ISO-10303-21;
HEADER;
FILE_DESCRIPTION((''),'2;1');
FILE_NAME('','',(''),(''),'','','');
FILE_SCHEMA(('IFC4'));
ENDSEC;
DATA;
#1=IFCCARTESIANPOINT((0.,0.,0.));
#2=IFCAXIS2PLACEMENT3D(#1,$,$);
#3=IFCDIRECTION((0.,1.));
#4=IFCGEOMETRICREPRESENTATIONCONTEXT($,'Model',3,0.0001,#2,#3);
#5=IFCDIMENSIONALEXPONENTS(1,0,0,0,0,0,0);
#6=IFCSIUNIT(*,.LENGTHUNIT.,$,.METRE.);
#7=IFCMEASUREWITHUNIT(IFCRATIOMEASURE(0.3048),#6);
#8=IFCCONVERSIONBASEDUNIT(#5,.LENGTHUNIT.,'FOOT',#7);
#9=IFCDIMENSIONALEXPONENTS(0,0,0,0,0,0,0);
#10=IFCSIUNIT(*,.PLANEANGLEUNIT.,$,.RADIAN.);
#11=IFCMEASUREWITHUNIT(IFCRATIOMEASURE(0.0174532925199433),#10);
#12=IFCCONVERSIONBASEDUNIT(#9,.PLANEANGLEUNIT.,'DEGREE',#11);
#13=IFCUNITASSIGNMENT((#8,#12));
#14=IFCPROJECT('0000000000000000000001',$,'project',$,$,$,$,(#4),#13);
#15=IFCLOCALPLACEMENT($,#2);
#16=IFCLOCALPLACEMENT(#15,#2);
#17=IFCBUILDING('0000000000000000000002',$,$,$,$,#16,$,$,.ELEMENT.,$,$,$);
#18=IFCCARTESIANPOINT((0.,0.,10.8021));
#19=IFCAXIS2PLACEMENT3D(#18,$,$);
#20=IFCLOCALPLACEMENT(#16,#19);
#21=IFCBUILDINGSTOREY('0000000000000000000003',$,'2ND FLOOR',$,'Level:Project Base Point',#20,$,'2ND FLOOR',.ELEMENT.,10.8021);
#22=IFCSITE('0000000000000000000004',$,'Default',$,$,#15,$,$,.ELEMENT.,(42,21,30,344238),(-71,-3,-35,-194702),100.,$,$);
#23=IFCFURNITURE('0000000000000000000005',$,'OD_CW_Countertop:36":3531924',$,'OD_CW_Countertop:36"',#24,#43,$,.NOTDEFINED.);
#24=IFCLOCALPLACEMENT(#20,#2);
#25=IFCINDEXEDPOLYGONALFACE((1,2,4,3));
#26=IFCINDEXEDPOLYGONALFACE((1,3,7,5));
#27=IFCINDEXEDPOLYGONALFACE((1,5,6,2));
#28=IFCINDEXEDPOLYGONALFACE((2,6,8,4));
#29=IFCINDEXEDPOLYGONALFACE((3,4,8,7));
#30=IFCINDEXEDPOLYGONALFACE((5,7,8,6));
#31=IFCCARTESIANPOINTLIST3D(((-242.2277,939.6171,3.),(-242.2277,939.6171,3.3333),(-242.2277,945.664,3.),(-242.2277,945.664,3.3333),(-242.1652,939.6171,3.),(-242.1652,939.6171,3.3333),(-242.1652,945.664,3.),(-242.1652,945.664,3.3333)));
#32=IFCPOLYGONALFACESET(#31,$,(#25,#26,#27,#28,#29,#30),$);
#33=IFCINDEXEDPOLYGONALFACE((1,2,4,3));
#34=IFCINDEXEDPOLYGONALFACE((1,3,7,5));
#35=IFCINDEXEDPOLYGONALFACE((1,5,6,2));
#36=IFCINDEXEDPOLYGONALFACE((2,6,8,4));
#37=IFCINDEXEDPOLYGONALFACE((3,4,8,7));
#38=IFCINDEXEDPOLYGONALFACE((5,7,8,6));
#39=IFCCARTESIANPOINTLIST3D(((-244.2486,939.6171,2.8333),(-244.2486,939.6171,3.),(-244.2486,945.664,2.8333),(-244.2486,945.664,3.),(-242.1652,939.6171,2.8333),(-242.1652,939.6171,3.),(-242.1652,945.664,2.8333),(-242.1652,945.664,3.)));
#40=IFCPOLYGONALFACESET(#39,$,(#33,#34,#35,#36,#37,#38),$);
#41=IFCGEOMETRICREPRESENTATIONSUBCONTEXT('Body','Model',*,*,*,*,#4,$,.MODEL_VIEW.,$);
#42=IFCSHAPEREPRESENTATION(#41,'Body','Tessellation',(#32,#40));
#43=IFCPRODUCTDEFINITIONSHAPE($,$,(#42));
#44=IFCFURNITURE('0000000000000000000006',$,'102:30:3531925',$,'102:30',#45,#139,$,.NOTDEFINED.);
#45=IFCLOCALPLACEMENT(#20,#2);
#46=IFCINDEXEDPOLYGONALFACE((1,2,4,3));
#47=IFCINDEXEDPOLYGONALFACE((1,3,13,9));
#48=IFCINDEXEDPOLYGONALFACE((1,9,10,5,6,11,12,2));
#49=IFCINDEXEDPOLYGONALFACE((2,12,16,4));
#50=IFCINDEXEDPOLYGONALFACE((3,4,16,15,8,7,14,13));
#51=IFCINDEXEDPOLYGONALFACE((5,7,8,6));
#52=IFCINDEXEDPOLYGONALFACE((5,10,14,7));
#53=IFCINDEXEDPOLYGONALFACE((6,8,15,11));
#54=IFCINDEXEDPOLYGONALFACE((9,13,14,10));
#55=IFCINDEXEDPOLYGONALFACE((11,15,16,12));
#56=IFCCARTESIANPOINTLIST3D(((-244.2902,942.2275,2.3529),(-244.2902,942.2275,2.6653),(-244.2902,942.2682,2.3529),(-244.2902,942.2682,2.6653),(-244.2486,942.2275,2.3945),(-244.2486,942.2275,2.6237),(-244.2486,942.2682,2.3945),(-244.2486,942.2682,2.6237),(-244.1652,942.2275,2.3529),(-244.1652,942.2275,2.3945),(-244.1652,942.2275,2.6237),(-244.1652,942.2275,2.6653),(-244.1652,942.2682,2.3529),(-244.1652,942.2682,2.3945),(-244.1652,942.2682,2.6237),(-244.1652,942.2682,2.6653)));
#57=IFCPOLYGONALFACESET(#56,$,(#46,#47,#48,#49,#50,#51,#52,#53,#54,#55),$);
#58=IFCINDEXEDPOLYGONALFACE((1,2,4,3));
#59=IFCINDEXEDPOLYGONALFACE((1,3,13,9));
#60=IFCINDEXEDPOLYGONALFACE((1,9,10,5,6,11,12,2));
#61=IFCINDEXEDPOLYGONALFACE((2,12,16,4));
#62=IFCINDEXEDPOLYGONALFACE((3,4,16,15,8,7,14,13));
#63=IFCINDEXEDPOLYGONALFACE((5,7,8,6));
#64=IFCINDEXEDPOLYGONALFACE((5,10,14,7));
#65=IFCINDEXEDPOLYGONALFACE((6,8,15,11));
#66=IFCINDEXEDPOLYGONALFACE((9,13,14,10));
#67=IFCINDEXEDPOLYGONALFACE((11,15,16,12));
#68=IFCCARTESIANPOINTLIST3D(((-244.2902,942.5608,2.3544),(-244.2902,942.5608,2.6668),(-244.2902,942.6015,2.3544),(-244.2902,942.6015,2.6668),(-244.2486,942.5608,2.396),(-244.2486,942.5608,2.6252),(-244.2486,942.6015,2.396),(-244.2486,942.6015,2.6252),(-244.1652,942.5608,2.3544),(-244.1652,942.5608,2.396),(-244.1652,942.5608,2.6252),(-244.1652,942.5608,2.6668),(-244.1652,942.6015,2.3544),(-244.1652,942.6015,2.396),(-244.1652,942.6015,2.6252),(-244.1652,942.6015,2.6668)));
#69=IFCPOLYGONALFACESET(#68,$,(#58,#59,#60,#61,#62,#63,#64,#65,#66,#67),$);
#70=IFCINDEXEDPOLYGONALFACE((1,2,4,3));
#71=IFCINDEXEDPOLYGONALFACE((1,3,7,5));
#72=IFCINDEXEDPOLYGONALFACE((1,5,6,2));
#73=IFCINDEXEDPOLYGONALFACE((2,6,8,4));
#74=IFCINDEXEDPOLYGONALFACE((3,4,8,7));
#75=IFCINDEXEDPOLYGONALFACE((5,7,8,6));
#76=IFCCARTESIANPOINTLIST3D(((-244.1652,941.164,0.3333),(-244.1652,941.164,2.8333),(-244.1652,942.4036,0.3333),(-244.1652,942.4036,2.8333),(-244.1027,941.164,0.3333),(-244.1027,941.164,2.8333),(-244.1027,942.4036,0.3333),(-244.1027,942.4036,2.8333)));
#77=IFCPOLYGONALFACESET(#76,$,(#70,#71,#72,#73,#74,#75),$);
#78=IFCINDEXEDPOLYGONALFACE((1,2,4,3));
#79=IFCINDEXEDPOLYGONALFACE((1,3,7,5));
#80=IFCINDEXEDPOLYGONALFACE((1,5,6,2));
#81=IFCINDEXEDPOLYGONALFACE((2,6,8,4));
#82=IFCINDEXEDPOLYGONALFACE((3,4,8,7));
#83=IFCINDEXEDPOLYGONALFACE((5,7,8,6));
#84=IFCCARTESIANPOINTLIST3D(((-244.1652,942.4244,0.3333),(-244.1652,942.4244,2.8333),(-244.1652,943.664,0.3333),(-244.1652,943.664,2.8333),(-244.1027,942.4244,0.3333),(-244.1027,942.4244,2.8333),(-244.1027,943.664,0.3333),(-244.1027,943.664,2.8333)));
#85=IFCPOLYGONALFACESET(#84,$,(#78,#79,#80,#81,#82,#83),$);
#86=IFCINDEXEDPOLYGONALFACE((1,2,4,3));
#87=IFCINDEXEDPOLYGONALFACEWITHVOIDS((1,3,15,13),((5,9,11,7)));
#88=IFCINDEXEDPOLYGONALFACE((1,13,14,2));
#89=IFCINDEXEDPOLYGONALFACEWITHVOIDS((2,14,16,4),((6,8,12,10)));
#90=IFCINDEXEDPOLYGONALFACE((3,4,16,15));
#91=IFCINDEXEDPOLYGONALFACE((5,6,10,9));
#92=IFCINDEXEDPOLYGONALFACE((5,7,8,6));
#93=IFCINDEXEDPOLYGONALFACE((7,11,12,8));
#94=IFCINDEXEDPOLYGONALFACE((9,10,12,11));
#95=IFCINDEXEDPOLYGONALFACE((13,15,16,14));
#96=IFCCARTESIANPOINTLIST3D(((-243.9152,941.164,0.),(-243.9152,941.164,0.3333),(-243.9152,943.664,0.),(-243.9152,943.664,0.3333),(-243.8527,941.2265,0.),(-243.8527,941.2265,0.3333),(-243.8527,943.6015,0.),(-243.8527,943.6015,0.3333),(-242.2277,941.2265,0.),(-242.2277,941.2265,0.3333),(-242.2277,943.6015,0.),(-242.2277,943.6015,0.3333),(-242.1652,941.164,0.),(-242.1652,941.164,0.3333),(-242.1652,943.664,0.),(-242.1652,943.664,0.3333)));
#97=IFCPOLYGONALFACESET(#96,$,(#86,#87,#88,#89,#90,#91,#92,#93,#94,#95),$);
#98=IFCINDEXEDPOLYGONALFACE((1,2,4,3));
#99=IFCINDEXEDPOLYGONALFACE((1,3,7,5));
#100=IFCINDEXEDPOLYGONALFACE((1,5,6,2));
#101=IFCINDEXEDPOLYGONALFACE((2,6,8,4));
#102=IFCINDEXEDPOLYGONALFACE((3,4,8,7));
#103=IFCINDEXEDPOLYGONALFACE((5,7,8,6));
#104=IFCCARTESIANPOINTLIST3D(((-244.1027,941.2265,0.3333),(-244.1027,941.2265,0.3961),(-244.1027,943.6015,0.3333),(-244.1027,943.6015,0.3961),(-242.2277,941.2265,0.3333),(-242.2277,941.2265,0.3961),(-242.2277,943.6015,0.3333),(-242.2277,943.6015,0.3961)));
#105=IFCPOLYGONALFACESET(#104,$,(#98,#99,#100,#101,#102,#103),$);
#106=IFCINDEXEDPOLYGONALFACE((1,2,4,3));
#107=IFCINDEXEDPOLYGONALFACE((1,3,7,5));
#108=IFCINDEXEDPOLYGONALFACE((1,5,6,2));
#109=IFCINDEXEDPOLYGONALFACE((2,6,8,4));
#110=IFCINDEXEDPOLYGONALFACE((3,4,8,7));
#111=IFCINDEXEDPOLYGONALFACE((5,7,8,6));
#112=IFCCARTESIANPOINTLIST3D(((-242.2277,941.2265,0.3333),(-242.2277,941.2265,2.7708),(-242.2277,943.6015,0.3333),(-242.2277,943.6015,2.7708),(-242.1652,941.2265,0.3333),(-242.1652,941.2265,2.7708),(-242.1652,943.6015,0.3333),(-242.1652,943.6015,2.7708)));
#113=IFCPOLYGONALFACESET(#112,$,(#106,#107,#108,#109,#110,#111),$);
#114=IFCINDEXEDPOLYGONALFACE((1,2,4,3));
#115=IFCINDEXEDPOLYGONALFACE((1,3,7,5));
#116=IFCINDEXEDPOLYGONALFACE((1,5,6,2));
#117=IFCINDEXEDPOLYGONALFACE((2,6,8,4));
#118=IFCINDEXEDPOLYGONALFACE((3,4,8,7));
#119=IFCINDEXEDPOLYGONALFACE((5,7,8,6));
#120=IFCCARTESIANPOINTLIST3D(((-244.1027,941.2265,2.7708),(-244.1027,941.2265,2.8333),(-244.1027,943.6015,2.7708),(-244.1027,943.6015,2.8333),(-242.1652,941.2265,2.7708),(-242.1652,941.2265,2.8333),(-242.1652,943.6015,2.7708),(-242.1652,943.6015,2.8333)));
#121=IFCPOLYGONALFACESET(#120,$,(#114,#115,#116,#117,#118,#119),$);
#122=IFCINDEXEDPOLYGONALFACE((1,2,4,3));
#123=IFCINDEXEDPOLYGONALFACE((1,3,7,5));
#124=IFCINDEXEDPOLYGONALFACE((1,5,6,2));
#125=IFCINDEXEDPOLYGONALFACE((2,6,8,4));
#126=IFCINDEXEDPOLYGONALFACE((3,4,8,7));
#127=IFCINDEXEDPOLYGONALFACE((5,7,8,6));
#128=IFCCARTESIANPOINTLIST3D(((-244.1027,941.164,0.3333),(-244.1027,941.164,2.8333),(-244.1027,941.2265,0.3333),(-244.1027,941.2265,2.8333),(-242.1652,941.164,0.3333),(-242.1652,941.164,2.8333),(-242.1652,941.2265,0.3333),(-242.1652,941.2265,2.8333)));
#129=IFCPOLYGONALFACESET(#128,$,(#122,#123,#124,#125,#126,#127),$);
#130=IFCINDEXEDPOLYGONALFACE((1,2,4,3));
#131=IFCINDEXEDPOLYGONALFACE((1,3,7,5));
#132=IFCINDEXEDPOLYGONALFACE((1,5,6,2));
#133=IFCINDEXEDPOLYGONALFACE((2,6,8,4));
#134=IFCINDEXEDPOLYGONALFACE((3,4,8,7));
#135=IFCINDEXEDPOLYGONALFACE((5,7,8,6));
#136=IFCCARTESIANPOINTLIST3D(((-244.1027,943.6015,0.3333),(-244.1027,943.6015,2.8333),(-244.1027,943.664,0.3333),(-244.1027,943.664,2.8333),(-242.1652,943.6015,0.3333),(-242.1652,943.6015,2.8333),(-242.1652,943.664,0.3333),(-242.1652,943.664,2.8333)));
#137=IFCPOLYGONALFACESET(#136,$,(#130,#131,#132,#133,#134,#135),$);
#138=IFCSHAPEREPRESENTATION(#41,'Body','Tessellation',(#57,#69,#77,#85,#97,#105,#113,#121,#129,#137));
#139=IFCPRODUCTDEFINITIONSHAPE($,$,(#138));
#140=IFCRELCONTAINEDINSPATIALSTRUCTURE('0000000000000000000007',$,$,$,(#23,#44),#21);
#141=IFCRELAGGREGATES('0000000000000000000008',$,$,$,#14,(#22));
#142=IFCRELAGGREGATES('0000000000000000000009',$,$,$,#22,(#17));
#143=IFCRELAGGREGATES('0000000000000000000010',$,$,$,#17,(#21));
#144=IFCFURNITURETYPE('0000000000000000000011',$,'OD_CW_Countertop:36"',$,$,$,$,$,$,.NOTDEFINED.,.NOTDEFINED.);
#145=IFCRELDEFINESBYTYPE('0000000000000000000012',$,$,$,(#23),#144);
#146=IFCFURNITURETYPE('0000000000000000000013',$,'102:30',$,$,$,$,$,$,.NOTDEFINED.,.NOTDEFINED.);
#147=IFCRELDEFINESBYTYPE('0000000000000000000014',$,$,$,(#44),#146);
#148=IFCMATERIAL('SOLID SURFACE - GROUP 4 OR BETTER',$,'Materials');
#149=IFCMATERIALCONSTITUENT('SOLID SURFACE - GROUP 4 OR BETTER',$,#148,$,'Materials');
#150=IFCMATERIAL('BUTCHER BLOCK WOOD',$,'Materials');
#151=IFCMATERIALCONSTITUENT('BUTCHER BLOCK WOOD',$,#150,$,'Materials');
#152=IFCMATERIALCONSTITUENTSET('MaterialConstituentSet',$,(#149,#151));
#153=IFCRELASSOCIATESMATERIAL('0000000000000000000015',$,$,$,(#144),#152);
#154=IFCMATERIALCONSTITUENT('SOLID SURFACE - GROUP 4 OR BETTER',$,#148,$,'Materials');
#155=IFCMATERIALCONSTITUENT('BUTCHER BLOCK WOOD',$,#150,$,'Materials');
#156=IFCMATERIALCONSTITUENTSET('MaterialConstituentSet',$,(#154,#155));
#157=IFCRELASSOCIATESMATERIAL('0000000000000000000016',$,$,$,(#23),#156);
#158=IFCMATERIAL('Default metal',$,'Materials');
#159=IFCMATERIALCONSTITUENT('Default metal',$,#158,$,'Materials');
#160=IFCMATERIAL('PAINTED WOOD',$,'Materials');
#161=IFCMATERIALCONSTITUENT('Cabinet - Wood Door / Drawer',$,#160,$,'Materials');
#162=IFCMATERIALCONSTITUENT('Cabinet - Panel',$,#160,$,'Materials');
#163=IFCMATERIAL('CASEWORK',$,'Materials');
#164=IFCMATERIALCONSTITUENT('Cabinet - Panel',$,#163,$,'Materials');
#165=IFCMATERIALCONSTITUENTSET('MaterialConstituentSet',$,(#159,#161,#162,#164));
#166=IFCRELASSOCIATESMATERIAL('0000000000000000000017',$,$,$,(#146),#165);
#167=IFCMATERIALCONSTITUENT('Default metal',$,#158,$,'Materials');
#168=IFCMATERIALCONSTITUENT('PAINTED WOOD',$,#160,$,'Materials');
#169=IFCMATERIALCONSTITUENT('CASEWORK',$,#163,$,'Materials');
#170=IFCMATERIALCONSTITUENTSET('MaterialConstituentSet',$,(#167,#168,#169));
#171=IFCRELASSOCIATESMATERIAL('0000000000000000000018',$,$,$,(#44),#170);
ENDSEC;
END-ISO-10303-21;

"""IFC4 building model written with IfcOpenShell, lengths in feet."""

from ifc_helpers import new_model, entity, si_unit, converted_unit, direction, frame, frame_2d, origin, origin_2d_with_axis, place, context, subcontext, project, spatial, polyline, rectangle, outline, extrude, source, transform, mapped, material, constituent, constituent_set, type_object, type_shapes, element, save


model = new_model("IFC4")

# Units and contexts
model_context = context("Model", 3, precision=0.0001, world=origin(), true_north=direction((0.0, 1.0)))
body_context = subcontext(model_context, "Body", "Model", "MODEL_VIEW")
ifc_project = project(units=[converted_unit("LENGTHUNIT", "FOOT", entity("IfcRatioMeasure", 0.3048), si_unit("LENGTHUNIT", "METRE"), dimensions=[1, 0, 0, 0, 0, 0, 0]), converted_unit("PLANEANGLEUNIT", "DEGREE", entity("IfcRatioMeasure", 0.0174532925199433), si_unit("PLANEANGLEUNIT", "RADIAN"), dimensions=[0, 0, 0, 0, 0, 0, 0])], contexts=[model_context])

# Site, building, storey
site_placement = place(None, origin())
site = spatial("IfcSite", under=ifc_project, at=site_placement, Name="Default", CompositionType="ELEMENT", RefLatitude=(42, 21, 30, 344238), RefLongitude=(-71, -3, -35, -194702), RefElevation=100.0)
building_placement = place(site_placement, origin())
building = spatial("IfcBuilding", under=site, at=building_placement, CompositionType="ELEMENT")
storey_placement = place(building_placement, frame((0.0, 0.0, 10.8021)))
storey = spatial("IfcBuildingStorey", under=building, at=storey_placement, Name="2ND FLOOR", ObjectType="Level:Project Base Point", LongName="2ND FLOOR", CompositionType="ELEMENT", Elevation=10.8021)

# Furniture
ifc_material_1 = material(Name="CASEWORK", Category="Materials")
ifc_material_2 = material(Name="PAINTED WOOD", Category="Materials")
ifc_material_3 = material(Name="SOLID SURFACE - GROUP 4 OR BETTER", Category="Materials")
ifc_constituent_1 = constituent(ifc_material_3, Name="SOLID SURFACE - GROUP 4 OR BETTER", Category="Materials")
ifc_material_4 = material(Name="BUTCHER BLOCK WOOD", Category="Materials")
ifc_constituent_2 = constituent(ifc_material_4, Name="BUTCHER BLOCK WOOD", Category="Materials")
ifc_constituent_set_1 = constituent_set(constituents=[ifc_constituent_1, ifc_constituent_2], Name="MaterialConstituentSet")
ifc_constituent_3 = constituent(ifc_material_3, Name="SOLID SURFACE - GROUP 4 OR BETTER", Category="Materials")
ifc_constituent_4 = constituent(ifc_material_4, Name="BUTCHER BLOCK WOOD", Category="Materials")
ifc_constituent_set_2 = constituent_set(constituents=[ifc_constituent_3, ifc_constituent_4], Name="MaterialConstituentSet")
furniture_type_1 = type_object("IfcFurnitureType", Name="OD_CW_Countertop:36\"", AssemblyPlace="NOTDEFINED", PredefinedType="NOTDEFINED", material=ifc_constituent_set_2)
shared_shape_1 = source(origin(), body_context, "Body", "SweptSolid", [
    extrude(rectangle(XDim=6.0469, YDim=0.0625, at=frame_2d((0.0, 0.0), x_axis=(1.0, 0.0))), frame((3.0234, 0.0313, 0.1667)), (0.0, 0.0, 1.0), 0.3333),
    extrude(rectangle(XDim=6.0469, YDim=2.0833, at=origin_2d_with_axis()), frame((3.0234, 1.0417, 0.0)), (0.0, 0.0, 1.0), 0.1667),
])
type_shapes(furniture_type_1, [shared_shape_1])
furniture_1_placement = place(storey_placement, frame((-242.1652, 939.6171, 2.8333), z_axis=(0.0, 0.0, 1.0), x_axis=(0.0, 1.0, 0.0)))
element("IfcFurniture", 1, at=furniture_1_placement, inside=storey, type_object=furniture_type_1, material=ifc_constituent_set_1, Name="OD_CW_Countertop:36\":3531924", ObjectType="OD_CW_Countertop:36\"", PredefinedType="NOTDEFINED", context=body_context, shape_type="MappedRepresentation", body=[
    mapped(shared_shape_1, transform((0.0, 0.0, 0.0), scale=1.0)),
])
ifc_material_5 = material(Name="Default metal", Category="Materials")
ifc_constituent_5 = constituent(ifc_material_5, Name="Default metal", Category="Materials")
ifc_constituent_6 = constituent(ifc_material_2, Name="PAINTED WOOD", Category="Materials")
ifc_constituent_7 = constituent(ifc_material_1, Name="CASEWORK", Category="Materials")
ifc_constituent_set_3 = constituent_set(constituents=[ifc_constituent_5, ifc_constituent_6, ifc_constituent_7], Name="MaterialConstituentSet")
ifc_constituent_8 = constituent(ifc_material_5, Name="Default metal", Category="Materials")
ifc_constituent_9 = constituent(ifc_material_2, Name="Cabinet - Wood Door / Drawer", Category="Materials")
ifc_constituent_10 = constituent(ifc_material_2, Name="Cabinet - Panel", Category="Materials")
ifc_constituent_11 = constituent(ifc_material_1, Name="Cabinet - Panel", Category="Materials")
ifc_constituent_set_4 = constituent_set(constituents=[ifc_constituent_8, ifc_constituent_9, ifc_constituent_10, ifc_constituent_11], Name="MaterialConstituentSet")
furniture_type_2 = type_object("IfcFurnitureType", Name="102:30", AssemblyPlace="NOTDEFINED", PredefinedType="NOTDEFINED", material=ifc_constituent_set_4)
shared_shape_2 = source(origin(), body_context, "Body", "SweptSolid", [
    extrude(outline(polyline([(0.1146, -0.0521), (0.1562, -0.0521), (0.1562, 0.0729), (-0.1562, 0.0729), (-0.1562, -0.0521), (-0.1146, -0.0521), (-0.1146, 0.0313), (0.1146, 0.0313), (0.1146, -0.0521)])), frame((0.2073, -2.0521, 2.5091), z_axis=(1.0, 0.0, 0.0), x_axis=(0.0, 0.0, 1.0)), (0.0, 0.0, 1.0), 0.0407),
    extrude(outline(polyline([(0.1146, -0.0521), (0.1562, -0.0521), (0.1562, 0.0729), (-0.1562, 0.0729), (-0.1562, -0.0521), (-0.1146, -0.0521), (-0.1146, 0.0313), (0.1146, 0.0313), (0.1146, -0.0521)])), frame((-0.126, -2.0521, 2.5106), z_axis=(1.0, 0.0, 0.0), x_axis=(0.0, 0.0, 1.0)), (0.0, 0.0, 1.0), 0.0407),
    extrude(rectangle(XDim=0.0625, YDim=1.2396, at=frame_2d((0.0, 0.0), x_axis=(1.0, 0.0))), frame((0.6917, -1.9688, 0.3333), z_axis=(0.0, 0.0, 1.0), x_axis=(0.0, 1.0, 0.0)), (0.0, 0.0, 1.0), 2.5),
    extrude(rectangle(XDim=0.0625, YDim=1.2396, at=origin_2d_with_axis()), frame((-0.5687, -1.9688, 0.3333), z_axis=(0.0, 0.0, 1.0), x_axis=(0.0, 1.0, 0.0)), (0.0, 0.0, 1.0), 2.5),
    extrude(outline(polyline([(-1.25, -0.875), (1.25, -0.875), (1.25, 0.875), (-1.25, 0.875), (-1.25, -0.875)]), holes=[polyline([(-1.1875, -0.8125), (-1.1875, 0.8125), (1.1875, 0.8125), (1.1875, -0.8125), (-1.1875, -0.8125)])]), frame((0.0615, -0.875, 0.0)), (0.0, 0.0, 1.0), 0.3333),
    extrude(rectangle(XDim=2.375, YDim=1.875, at=frame_2d((0.0, 0.0), x_axis=(1.0, 0.0))), frame((0.0615, -1.0, 0.3333), z_axis=(0.0, 0.0, 1.0), x_axis=(-1.0, 0.0, 0.0)), (0.0, 0.0, 1.0), 0.0627),
    extrude(rectangle(XDim=0.0625, YDim=2.375, at=origin_2d_with_axis()), frame((0.0615, -0.0312, 0.3333), z_axis=(0.0, 0.0, 1.0), x_axis=(0.0, 1.0, 0.0)), (0.0, 0.0, 1.0), 2.4375),
    extrude(rectangle(XDim=2.375, YDim=1.9375, at=origin_2d_with_axis()), frame((0.0615, -0.9688, 2.7708), z_axis=(0.0, 0.0, 1.0), x_axis=(-1.0, 0.0, 0.0)), (0.0, 0.0, 1.0), 0.0625),
    extrude(rectangle(XDim=0.0625, YDim=1.9375, at=frame_2d((0.0, 0.0), x_axis=(1.0, 0.0))), frame((1.2802, -0.9687, 0.3333)), (0.0, 0.0, 1.0), 2.5),
    extrude(rectangle(XDim=0.0625, YDim=1.9375, at=frame_2d((0.0, 0.0), x_axis=(1.0, 0.0))), frame((-1.1573, -0.9687, 0.3333)), (0.0, 0.0, 1.0), 2.5),
])
type_shapes(furniture_type_2, [shared_shape_2])
furniture_2_placement = place(storey_placement, frame((-242.1652, 942.4755, 0.0), z_axis=(0.0, 0.0, 1.0), x_axis=(0.0, -1.0, 0.0)))
element("IfcFurniture", 2, at=furniture_2_placement, inside=storey, type_object=furniture_type_2, material=ifc_constituent_set_3, Name="102:30:3531925", ObjectType="102:30", PredefinedType="NOTDEFINED", context=body_context, shape_type="MappedRepresentation", body=[
    mapped(shared_shape_2, transform((0.0, 0.0, 0.0), scale=1.0)),
])

save(model, "model.ifc")
